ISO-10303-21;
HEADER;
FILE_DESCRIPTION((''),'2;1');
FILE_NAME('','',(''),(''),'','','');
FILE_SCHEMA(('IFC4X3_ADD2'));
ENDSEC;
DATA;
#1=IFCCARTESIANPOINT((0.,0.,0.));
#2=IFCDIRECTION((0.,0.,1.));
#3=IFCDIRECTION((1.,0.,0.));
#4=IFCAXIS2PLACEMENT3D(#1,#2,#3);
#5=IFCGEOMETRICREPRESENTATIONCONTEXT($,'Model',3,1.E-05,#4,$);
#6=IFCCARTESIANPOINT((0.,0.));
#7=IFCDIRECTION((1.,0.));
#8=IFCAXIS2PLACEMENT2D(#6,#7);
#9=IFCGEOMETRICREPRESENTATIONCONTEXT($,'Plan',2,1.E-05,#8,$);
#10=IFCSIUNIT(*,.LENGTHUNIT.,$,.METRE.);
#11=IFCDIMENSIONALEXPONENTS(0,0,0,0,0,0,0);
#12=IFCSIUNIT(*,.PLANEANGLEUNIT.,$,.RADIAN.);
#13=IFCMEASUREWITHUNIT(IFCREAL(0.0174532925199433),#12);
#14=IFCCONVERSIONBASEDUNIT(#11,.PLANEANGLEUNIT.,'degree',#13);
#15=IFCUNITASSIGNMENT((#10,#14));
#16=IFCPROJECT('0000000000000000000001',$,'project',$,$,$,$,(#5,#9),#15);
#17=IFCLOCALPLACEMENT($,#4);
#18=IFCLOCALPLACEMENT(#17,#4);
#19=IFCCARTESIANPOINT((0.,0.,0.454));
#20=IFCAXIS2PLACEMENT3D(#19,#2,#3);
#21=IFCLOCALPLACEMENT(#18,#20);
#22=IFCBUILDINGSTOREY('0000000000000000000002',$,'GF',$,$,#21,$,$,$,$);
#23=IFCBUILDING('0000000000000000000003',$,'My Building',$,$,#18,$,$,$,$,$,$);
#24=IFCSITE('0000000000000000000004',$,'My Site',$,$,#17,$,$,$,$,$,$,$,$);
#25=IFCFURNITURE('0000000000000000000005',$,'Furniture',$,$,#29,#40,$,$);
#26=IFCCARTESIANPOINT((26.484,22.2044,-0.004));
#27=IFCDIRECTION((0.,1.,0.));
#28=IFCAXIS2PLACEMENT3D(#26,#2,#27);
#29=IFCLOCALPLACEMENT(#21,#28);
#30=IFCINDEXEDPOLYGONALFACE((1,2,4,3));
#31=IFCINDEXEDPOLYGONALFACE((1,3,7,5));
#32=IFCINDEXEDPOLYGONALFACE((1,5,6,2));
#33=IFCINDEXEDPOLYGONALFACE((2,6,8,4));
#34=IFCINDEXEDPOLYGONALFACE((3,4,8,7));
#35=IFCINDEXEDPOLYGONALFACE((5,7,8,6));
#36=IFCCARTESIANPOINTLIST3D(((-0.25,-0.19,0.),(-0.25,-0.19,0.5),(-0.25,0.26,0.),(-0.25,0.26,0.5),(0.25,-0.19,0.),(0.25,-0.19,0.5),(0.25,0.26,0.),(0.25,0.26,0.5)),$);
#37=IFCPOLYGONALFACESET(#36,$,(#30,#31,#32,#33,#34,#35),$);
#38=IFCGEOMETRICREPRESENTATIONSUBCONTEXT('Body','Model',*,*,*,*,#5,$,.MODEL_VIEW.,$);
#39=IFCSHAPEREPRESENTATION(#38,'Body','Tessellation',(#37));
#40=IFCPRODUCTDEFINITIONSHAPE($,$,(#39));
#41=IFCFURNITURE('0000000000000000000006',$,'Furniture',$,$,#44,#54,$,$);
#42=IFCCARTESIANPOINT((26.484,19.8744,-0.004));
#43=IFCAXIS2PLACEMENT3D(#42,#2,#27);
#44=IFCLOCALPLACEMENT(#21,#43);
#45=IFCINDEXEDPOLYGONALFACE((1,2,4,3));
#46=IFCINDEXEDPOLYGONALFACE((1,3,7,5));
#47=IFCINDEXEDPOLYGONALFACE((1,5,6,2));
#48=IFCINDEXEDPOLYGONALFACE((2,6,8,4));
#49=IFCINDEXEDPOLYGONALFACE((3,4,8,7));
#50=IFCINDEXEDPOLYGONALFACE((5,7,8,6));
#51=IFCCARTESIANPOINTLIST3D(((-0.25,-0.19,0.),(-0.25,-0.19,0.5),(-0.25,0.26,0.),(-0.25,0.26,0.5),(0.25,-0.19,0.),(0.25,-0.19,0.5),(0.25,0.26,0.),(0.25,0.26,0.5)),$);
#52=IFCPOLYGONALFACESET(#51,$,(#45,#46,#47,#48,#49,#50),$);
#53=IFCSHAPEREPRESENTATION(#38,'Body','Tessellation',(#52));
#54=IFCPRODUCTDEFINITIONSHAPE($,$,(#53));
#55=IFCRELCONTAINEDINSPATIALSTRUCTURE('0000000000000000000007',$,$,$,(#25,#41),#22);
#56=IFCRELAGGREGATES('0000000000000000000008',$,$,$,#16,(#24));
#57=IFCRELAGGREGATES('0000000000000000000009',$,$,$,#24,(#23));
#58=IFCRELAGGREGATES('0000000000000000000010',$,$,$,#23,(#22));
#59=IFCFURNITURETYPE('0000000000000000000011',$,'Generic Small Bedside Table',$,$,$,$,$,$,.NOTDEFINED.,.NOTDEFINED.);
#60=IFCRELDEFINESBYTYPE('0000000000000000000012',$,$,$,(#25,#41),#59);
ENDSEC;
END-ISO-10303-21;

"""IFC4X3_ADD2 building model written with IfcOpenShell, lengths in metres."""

from ifc_helpers import new_model, entity, si_unit, converted_unit, frame, origin_with_axes, origin_2d_with_axis, place, context, subcontext, project, spatial, line, indexed_curve, outline, extrude, shape, source, transform, mapped, type_object, type_shapes, element, save


model = new_model("IFC4X3_ADD2")

# Units and contexts
model_context = context("Model", 3, precision=1e-05, world=origin_with_axes())
plan_context = context("Plan", 2, precision=1e-05, world=origin_2d_with_axis())
body_context_1 = subcontext(model_context, "Body", "Model", "MODEL_VIEW")
body_context_2 = subcontext(plan_context, "Body", "Plan", "PLAN_VIEW")
ifc_project = project(units=[si_unit("LENGTHUNIT", "METRE"), converted_unit("PLANEANGLEUNIT", "degree", entity("IfcReal", 0.0174532925199433), si_unit("PLANEANGLEUNIT", "RADIAN"), dimensions=[0, 0, 0, 0, 0, 0, 0])], contexts=[model_context, plan_context])

# Site, building, storey
site_placement = place(None, origin_with_axes())
site = spatial("IfcSite", under=ifc_project, at=site_placement, Name="My Site")
building_placement = place(site_placement, origin_with_axes())
building = spatial("IfcBuilding", under=site, at=building_placement, Name="My Building")
storey_placement = place(building_placement, frame((0.0, 0.0, 0.454), z_axis=(0.0, 0.0, 1.0), x_axis=(1.0, 0.0, 0.0)))
storey = spatial("IfcBuildingStorey", under=building, at=storey_placement, Name="GF")

# Furniture
furniture_type = type_object("IfcFurnitureType", Name="Generic Small Bedside Table", AssemblyPlace="NOTDEFINED", PredefinedType="NOTDEFINED")
shared_shape_1 = source(origin_with_axes(), body_context_1, "Body", "SweptSolid", [
    extrude(outline(indexed_curve([(0.5, 0.45), (0.5, 0.0), (0.0, 0.0), (0.0, 0.45)], segments=[line(4, 1), line(1, 2), line(2, 3), line(3, 4)], self_intersect=False)), frame((-0.25, -0.19, 0.0), z_axis=(0.0, 0.0, 1.0), x_axis=(1.0, 0.0, 0.0)), (0.0, 0.0, 1.0), 0.5),
])
shared_shape_2 = source(origin_with_axes(), body_context_2, "Body", "Annotation2D", [
    entity("IfcGeometricCurveSet", [entity("IfcIndexedPolyCurve", entity("IfcCartesianPointList2D", [[-0.25, -0.19], [0.25, -0.19], [0.25, 0.26], [-0.25, 0.26]]), [entity("IfcLineIndex", [1, 2]), entity("IfcLineIndex", [2, 3]), entity("IfcLineIndex", [3, 4]), entity("IfcLineIndex", [4, 1])])]),
])
type_shapes(furniture_type, [shared_shape_1, shared_shape_2])
for number, where, z_axis, x_axis, name in (
    (1, (26.484, 22.2044, -0.004), (0.0, 0.0, 1.0), (0.0, 1.0, 0.0), "Furniture"),
    (2, (26.484, 19.8744, -0.004), (0.0, 0.0, 1.0), (0.0, 1.0, 0.0), "Furniture"),
):
    element("IfcFurniture", number, at=place(storey_placement, frame(where, z_axis=z_axis, x_axis=x_axis)), inside=storey, type_object=furniture_type, Name=name, shapes=[
        shape(body_context_1, "Body", "MappedRepresentation", [mapped(shared_shape_1, transform((0.0, 0.0, 0.0), x_axis=(1.0, 0.0, 0.0), y_axis=(0.0, 1.0, 0.0), z_axis=(0.0, 0.0, 1.0), scale=1.0))]),
        shape(body_context_2, "Body", "MappedRepresentation", [mapped(shared_shape_2, transform((0.0, 0.0, 0.0), x_axis=(1.0, 0.0, 0.0), y_axis=(0.0, 1.0, 0.0), z_axis=(0.0, 0.0, 1.0), scale=1.0))]),
    ])

save(model, "model.ifc")
